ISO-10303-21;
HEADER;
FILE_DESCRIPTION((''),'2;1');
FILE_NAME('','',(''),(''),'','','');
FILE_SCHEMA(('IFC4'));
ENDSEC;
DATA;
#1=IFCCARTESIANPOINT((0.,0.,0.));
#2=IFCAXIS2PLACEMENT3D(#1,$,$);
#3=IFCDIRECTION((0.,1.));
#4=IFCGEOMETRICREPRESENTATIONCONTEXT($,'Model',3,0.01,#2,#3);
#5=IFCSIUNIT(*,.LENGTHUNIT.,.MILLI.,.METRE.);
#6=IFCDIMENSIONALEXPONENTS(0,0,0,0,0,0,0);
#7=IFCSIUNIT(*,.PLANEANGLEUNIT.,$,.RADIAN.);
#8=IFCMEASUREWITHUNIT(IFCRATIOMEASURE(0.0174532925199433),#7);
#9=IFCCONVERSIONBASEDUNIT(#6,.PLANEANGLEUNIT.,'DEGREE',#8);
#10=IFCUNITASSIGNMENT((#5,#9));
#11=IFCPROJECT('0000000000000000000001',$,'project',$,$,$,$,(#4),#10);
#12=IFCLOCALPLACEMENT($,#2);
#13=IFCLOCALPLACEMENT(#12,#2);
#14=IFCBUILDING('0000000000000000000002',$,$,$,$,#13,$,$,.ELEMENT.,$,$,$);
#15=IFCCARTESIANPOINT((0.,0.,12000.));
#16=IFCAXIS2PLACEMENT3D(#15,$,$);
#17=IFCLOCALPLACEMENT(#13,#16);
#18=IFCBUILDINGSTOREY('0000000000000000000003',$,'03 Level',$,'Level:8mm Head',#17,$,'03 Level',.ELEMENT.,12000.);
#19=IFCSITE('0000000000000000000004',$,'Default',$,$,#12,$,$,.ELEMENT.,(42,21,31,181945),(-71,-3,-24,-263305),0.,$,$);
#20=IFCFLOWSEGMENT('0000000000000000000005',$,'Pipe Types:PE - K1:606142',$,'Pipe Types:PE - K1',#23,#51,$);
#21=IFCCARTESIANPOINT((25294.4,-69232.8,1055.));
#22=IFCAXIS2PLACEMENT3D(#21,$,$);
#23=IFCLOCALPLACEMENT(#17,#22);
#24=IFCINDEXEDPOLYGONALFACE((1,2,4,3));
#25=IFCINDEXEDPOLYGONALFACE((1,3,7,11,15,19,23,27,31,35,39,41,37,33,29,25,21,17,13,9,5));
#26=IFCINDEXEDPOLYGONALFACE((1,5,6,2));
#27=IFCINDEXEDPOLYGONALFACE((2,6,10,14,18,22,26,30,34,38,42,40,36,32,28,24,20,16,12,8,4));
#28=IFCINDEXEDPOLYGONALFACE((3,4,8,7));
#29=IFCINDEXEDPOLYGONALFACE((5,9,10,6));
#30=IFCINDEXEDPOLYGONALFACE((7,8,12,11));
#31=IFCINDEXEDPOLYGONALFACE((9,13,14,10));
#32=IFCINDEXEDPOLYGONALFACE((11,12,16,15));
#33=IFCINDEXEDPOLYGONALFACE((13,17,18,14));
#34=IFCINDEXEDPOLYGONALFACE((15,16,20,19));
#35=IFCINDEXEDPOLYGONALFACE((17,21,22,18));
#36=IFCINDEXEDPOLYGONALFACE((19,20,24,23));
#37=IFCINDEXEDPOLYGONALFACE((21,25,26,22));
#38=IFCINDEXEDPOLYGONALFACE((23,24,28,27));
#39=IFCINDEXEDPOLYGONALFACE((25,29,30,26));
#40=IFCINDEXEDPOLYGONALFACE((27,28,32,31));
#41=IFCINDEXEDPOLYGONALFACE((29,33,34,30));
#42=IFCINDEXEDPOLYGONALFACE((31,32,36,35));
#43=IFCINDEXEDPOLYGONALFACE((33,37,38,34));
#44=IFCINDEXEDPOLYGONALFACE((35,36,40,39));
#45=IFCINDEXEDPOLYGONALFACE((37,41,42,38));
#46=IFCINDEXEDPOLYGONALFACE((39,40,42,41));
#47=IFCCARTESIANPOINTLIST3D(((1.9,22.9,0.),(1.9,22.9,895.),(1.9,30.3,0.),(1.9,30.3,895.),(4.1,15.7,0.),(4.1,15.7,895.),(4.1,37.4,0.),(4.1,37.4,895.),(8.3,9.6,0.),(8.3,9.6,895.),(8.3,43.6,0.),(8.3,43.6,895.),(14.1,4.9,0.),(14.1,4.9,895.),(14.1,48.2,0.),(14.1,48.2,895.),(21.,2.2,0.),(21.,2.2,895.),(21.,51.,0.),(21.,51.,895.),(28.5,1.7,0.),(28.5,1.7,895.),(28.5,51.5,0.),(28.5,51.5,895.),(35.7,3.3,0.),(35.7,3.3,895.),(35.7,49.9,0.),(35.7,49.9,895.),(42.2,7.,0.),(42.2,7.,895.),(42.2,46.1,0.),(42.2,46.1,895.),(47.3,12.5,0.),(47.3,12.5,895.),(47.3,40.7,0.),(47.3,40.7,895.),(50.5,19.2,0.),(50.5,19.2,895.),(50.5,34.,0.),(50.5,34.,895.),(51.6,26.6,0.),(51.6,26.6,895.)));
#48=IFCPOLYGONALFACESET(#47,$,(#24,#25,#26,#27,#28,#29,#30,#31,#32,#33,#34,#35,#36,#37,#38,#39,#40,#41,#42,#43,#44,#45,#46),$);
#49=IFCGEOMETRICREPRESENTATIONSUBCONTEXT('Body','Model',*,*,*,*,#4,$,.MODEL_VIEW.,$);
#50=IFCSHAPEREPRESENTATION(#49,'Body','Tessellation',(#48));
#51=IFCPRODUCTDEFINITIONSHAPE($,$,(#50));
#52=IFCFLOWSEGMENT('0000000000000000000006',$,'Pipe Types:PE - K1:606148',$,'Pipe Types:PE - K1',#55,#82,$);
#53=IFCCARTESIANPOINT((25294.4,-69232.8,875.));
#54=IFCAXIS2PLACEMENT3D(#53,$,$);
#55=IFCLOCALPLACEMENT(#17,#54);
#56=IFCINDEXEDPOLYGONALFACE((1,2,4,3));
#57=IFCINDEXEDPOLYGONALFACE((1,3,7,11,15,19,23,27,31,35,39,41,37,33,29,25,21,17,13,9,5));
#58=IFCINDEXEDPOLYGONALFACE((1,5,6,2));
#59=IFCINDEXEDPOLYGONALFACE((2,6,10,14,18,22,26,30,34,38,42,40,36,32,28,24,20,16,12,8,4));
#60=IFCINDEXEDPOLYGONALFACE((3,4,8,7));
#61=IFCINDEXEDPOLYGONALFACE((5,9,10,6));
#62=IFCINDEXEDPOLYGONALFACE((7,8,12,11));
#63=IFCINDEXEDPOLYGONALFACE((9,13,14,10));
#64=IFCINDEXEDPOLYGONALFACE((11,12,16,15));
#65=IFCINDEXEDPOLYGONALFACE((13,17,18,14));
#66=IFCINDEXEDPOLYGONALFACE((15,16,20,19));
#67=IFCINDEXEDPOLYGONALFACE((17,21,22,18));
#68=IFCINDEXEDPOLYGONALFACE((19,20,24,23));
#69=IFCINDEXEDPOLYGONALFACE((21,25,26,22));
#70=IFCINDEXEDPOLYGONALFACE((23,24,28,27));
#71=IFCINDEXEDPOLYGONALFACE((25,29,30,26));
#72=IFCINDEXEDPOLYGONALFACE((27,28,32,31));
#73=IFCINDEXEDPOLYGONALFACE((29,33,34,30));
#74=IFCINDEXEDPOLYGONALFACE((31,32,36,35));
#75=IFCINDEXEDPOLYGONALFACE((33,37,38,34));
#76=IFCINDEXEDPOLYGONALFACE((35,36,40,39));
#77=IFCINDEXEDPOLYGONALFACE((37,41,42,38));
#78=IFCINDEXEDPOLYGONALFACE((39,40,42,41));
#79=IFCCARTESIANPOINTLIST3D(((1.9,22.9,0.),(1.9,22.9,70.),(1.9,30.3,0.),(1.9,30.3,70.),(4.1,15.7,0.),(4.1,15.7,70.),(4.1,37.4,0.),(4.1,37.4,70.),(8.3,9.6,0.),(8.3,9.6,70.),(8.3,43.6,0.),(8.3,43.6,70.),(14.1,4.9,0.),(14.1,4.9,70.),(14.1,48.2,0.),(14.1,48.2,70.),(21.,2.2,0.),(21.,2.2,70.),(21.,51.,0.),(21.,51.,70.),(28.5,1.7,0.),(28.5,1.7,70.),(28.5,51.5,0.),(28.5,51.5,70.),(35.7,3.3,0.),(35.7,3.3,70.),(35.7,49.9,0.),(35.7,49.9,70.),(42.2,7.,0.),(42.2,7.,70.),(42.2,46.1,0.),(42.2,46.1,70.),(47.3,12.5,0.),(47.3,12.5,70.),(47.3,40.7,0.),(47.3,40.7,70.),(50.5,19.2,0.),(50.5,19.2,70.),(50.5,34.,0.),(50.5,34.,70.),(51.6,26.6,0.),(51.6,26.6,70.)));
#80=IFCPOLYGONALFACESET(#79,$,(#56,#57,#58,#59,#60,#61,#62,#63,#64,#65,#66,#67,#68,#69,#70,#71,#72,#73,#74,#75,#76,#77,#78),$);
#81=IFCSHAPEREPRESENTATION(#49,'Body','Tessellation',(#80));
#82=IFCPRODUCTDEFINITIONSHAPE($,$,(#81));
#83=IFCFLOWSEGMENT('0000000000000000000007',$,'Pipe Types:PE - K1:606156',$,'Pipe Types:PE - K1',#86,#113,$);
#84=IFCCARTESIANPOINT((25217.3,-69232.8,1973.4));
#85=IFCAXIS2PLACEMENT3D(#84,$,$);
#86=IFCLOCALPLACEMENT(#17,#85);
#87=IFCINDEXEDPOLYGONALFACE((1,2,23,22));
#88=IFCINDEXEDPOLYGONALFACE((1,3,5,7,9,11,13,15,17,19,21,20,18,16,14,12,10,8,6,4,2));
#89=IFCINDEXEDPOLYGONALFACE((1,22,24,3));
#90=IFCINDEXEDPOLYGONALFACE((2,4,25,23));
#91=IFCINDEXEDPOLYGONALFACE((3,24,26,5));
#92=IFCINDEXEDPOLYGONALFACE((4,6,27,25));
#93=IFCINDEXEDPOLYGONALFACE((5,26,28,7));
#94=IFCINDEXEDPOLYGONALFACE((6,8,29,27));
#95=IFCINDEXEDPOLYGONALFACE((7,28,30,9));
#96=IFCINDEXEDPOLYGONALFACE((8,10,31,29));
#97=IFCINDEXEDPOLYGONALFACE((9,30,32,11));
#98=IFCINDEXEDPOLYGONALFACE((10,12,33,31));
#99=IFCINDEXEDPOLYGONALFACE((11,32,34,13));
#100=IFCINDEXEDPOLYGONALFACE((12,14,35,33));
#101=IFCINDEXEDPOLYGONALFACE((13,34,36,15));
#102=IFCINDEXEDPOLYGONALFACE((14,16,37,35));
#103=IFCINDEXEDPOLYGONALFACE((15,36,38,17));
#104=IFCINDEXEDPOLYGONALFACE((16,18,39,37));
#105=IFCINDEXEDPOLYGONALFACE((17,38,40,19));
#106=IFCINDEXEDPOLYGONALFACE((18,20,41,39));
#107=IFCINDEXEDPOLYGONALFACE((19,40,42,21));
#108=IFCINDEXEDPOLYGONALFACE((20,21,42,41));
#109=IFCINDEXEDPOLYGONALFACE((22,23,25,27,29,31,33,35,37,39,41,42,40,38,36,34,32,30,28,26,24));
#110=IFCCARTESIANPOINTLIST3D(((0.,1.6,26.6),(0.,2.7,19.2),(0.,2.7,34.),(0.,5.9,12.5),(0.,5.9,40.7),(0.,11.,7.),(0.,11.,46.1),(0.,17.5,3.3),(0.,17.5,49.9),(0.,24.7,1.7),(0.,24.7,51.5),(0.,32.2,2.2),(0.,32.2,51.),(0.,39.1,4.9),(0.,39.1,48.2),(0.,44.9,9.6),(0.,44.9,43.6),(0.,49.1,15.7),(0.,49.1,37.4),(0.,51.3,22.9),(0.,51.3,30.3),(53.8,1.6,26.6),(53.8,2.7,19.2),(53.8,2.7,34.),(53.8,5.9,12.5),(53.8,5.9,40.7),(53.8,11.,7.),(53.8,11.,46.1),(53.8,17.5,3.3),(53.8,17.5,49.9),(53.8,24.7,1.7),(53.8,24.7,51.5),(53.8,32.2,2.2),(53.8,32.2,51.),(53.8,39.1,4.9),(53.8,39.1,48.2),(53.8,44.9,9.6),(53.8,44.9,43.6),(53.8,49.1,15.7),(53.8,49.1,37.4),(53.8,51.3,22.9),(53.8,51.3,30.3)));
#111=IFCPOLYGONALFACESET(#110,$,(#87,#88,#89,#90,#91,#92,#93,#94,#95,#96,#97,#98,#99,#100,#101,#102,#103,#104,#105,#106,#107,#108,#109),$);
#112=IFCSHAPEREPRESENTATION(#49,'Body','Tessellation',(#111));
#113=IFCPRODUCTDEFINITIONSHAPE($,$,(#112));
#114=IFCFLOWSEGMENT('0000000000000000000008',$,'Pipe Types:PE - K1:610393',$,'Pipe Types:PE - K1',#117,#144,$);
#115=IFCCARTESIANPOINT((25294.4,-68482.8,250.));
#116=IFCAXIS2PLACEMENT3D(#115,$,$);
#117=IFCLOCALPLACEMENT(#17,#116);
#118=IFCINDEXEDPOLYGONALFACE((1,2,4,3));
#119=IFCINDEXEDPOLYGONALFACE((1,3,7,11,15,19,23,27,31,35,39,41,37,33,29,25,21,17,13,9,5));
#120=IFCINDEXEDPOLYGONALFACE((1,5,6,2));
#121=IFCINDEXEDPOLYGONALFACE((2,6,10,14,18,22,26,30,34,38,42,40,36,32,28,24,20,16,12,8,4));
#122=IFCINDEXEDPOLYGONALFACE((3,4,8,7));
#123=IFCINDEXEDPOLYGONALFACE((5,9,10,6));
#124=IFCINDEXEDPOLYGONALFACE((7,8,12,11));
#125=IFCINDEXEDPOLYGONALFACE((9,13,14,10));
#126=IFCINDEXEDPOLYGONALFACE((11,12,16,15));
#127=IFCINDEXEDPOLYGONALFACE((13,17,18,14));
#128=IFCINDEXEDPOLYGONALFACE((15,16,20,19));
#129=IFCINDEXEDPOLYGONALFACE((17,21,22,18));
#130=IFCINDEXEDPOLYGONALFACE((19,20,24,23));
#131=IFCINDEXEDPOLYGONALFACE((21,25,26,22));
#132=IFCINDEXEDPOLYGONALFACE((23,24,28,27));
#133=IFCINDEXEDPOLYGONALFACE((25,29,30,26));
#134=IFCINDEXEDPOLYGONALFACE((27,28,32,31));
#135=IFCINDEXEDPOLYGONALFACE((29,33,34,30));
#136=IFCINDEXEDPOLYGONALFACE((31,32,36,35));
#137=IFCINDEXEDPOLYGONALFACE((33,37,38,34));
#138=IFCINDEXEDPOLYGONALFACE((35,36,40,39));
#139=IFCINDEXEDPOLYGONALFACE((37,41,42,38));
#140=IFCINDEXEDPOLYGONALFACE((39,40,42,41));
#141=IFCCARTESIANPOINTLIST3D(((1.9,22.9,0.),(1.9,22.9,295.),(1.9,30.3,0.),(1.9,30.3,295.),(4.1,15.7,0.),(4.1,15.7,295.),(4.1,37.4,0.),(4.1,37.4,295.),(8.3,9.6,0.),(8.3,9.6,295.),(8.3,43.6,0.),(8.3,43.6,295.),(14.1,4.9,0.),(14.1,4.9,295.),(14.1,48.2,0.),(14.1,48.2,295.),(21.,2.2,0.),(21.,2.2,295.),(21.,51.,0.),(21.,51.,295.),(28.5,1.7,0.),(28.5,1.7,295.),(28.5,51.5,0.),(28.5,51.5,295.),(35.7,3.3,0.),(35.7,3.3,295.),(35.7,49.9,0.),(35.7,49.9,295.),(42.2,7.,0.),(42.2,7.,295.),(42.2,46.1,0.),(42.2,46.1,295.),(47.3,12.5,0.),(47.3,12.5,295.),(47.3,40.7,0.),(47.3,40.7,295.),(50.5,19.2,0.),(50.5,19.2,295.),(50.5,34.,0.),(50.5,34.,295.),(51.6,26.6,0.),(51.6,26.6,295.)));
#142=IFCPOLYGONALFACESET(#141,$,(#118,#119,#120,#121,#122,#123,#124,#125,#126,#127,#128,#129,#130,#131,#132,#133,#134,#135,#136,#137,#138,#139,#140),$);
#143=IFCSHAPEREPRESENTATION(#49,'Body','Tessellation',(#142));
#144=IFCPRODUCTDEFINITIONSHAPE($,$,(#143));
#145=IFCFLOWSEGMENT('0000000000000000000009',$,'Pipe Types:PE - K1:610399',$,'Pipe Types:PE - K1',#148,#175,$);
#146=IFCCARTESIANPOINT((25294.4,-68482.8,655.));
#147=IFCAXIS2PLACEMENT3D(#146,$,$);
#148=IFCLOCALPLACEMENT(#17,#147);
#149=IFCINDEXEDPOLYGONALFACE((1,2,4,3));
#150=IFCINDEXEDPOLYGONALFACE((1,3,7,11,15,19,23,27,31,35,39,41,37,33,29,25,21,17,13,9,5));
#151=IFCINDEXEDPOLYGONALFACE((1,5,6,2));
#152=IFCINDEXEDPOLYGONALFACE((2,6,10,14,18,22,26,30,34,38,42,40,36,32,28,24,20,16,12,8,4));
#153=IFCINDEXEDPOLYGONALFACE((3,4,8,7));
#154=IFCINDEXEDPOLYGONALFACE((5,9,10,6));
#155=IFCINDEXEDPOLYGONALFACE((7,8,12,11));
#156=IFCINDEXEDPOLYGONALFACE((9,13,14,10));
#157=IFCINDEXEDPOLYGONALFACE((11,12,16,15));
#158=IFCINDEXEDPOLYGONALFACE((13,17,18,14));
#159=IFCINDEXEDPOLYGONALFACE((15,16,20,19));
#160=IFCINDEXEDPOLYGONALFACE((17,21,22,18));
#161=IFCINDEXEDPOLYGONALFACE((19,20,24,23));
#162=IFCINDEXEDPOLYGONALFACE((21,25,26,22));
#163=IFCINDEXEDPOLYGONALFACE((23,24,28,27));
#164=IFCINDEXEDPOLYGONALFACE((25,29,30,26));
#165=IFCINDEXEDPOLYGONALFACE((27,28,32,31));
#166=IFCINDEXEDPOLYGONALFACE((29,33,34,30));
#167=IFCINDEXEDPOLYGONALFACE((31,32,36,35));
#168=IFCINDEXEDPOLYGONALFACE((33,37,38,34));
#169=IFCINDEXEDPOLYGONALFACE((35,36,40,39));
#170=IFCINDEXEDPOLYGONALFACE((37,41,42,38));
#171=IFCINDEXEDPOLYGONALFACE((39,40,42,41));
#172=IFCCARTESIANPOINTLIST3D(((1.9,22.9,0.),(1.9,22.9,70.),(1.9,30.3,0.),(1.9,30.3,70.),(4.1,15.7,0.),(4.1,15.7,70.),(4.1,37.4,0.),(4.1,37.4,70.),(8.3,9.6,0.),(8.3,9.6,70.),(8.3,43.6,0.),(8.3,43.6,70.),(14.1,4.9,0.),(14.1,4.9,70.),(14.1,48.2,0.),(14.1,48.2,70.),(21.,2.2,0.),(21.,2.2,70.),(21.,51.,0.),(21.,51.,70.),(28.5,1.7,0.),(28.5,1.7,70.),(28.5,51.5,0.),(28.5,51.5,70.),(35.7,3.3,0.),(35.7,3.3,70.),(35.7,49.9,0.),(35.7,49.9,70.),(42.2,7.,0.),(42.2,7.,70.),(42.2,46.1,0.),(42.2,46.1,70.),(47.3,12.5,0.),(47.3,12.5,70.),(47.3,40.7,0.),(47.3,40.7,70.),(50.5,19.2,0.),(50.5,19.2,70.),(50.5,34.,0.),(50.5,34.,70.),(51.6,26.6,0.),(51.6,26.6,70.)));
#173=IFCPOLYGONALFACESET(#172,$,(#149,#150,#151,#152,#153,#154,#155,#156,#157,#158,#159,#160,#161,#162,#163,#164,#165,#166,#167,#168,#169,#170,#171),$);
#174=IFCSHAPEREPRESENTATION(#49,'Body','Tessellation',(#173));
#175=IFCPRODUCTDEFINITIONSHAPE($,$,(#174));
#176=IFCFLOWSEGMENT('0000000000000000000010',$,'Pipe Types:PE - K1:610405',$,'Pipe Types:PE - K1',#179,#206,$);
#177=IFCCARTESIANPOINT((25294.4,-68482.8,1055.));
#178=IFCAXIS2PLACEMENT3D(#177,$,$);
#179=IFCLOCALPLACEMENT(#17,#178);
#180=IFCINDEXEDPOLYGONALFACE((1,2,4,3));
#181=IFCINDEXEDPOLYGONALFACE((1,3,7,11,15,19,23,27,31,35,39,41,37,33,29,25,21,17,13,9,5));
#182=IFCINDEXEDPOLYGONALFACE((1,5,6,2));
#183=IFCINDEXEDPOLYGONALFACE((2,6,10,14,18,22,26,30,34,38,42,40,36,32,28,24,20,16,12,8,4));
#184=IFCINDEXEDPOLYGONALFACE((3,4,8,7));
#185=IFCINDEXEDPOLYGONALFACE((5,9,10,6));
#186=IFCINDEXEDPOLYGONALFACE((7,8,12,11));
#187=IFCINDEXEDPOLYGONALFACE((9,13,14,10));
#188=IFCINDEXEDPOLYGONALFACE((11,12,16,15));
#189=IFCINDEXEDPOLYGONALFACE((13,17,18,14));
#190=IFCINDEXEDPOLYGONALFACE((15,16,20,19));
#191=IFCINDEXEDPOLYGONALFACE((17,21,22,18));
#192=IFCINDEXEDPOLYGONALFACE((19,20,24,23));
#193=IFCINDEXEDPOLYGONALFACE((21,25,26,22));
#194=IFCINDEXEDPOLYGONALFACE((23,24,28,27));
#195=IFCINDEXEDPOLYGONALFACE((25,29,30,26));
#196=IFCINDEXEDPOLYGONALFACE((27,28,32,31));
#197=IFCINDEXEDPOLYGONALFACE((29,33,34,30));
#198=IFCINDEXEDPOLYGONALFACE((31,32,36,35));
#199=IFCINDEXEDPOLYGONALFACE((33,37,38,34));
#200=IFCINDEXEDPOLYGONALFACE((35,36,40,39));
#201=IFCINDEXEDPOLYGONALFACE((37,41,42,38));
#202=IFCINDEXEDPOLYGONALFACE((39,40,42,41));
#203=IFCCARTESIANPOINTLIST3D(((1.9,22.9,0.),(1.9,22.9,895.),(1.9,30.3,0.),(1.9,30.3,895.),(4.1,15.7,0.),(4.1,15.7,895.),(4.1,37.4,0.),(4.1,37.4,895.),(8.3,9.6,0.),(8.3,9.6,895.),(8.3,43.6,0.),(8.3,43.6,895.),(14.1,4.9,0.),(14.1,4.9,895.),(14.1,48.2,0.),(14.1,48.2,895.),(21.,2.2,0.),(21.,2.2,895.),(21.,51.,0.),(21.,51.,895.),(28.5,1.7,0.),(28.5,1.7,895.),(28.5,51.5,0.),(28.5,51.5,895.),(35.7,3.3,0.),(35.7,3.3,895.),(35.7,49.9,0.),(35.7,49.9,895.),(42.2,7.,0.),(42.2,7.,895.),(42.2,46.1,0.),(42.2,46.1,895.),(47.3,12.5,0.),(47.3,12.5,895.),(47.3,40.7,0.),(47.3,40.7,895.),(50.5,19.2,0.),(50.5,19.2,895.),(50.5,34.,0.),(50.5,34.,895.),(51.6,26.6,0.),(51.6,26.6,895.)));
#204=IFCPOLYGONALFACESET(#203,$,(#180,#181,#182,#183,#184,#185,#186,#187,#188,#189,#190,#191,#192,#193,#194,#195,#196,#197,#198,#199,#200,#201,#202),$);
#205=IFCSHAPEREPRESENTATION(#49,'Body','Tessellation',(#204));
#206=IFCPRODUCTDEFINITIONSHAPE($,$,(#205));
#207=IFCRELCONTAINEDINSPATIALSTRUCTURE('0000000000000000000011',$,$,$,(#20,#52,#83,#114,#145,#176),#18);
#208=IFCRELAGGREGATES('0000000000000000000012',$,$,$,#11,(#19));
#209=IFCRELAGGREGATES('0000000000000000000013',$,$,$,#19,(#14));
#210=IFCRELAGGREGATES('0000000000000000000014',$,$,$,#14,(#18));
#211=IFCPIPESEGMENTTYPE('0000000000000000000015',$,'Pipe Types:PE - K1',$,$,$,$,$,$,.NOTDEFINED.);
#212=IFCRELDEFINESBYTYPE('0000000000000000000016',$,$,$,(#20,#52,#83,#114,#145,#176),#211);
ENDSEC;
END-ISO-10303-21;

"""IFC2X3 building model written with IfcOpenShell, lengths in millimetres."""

from ifc_helpers import new_model, entity, si_unit, converted_unit, direction, frame, frame_2d, origin, origin_2d_with_axis, place, context, subcontext, project, spatial, circle, extrude, type_object, element, save


model = new_model("IFC2X3")

# Units and contexts
model_context = context("Model", 3, precision=0.01, world=origin(), true_north=direction((0.0, 1.0)))
body_context = subcontext(model_context, "Body", "Model", "MODEL_VIEW")
ifc_project = project(units=[si_unit("LENGTHUNIT", "METRE", prefix="MILLI"), converted_unit("PLANEANGLEUNIT", "DEGREE", entity("IfcRatioMeasure", 0.0174532925199433), si_unit("PLANEANGLEUNIT", "RADIAN"), dimensions=[0, 0, 0, 0, 0, 0, 0])], contexts=[model_context])

# Site, building, storey
site_placement = place(None, origin())
site = spatial("IfcSite", under=ifc_project, at=site_placement, Name="Default", CompositionType="ELEMENT", RefLatitude=(42, 21, 31, 181945), RefLongitude=(-71, -3, -24, -263305), RefElevation=0.0)
building_placement = place(site_placement, origin())
building = spatial("IfcBuilding", under=site, at=building_placement, CompositionType="ELEMENT")
storey_placement = place(building_placement, frame((0.0, 0.0, 12000.0)))
storey = spatial("IfcBuildingStorey", under=building, at=storey_placement, Name="03 Level", ObjectType="Level:8mm Head", LongName="03 Level", CompositionType="ELEMENT", Elevation=12000.0)

# Flow segments
pipe_segment_type_1 = type_object("IfcPipeSegmentType", Name="Pipe Types:PE - K1", PredefinedType="NOTDEFINED")
flow_segment_1_placement = place(storey_placement, frame((25294.4, -69232.8, 1055.0)))
element("IfcFlowSegment", 1, at=flow_segment_1_placement, inside=storey, type_object=pipe_segment_type_1, Name="Pipe Types:PE - K1:606142", ObjectType="Pipe Types:PE - K1", context=body_context, shape_type="SweptSolid", body=[
    extrude(circle(Radius=25.0, at=origin_2d_with_axis()), frame((26.6, 26.6, 0.0)), (0.0, 0.0, 1.0), 895.0),
])
flow_segment_2_placement = place(storey_placement, frame((25294.4, -69232.8, 875.0)))
element("IfcFlowSegment", 2, at=flow_segment_2_placement, inside=storey, type_object=pipe_segment_type_1, Name="Pipe Types:PE - K1:606148", ObjectType="Pipe Types:PE - K1", context=body_context, shape_type="SweptSolid", body=[
    extrude(circle(Radius=25.0, at=origin_2d_with_axis()), frame((26.6, 26.6, 0.0)), (0.0, 0.0, 1.0), 70.0),
])
flow_segment_3_placement = place(storey_placement, frame((25217.3, -69232.8, 1973.4)))
element("IfcFlowSegment", 3, at=flow_segment_3_placement, inside=storey, type_object=pipe_segment_type_1, Name="Pipe Types:PE - K1:606156", ObjectType="Pipe Types:PE - K1", context=body_context, shape_type="SweptSolid", body=[
    extrude(circle(Radius=25.0, at=frame_2d((0.0, 0.0), x_axis=(1.0, 0.0))), frame((0.0, 26.6, 26.6), z_axis=(1.0, 0.0, 0.0), x_axis=(0.0, -1.0, 0.0)), (0.0, 0.0, 1.0), 53.8),
])
flow_segment_4_placement = place(storey_placement, frame((25294.4, -68482.8, 250.0)))
element("IfcFlowSegment", 4, at=flow_segment_4_placement, inside=storey, type_object=pipe_segment_type_1, Name="Pipe Types:PE - K1:610393", ObjectType="Pipe Types:PE - K1", context=body_context, shape_type="SweptSolid", body=[
    extrude(circle(Radius=25.0, at=origin_2d_with_axis()), frame((26.6, 26.6, 0.0)), (0.0, 0.0, 1.0), 295.0),
])
flow_segment_5_placement = place(storey_placement, frame((25294.4, -68482.8, 655.0)))
element("IfcFlowSegment", 5, at=flow_segment_5_placement, inside=storey, type_object=pipe_segment_type_1, Name="Pipe Types:PE - K1:610399", ObjectType="Pipe Types:PE - K1", context=body_context, shape_type="SweptSolid", body=[
    extrude(circle(Radius=25.0, at=origin_2d_with_axis()), frame((26.6, 26.6, 0.0)), (0.0, 0.0, 1.0), 70.0),
])
flow_segment_6_placement = place(storey_placement, frame((25294.4, -68482.8, 1055.0)))
element("IfcFlowSegment", 6, at=flow_segment_6_placement, inside=storey, type_object=pipe_segment_type_1, Name="Pipe Types:PE - K1:610405", ObjectType="Pipe Types:PE - K1", context=body_context, shape_type="SweptSolid", body=[
    extrude(circle(Radius=25.0, at=frame_2d((0.0, 0.0), x_axis=(1.0, 0.0))), frame((26.6, 26.6, 0.0)), (0.0, 0.0, 1.0), 895.0),
])

save(model, "model.ifc")
